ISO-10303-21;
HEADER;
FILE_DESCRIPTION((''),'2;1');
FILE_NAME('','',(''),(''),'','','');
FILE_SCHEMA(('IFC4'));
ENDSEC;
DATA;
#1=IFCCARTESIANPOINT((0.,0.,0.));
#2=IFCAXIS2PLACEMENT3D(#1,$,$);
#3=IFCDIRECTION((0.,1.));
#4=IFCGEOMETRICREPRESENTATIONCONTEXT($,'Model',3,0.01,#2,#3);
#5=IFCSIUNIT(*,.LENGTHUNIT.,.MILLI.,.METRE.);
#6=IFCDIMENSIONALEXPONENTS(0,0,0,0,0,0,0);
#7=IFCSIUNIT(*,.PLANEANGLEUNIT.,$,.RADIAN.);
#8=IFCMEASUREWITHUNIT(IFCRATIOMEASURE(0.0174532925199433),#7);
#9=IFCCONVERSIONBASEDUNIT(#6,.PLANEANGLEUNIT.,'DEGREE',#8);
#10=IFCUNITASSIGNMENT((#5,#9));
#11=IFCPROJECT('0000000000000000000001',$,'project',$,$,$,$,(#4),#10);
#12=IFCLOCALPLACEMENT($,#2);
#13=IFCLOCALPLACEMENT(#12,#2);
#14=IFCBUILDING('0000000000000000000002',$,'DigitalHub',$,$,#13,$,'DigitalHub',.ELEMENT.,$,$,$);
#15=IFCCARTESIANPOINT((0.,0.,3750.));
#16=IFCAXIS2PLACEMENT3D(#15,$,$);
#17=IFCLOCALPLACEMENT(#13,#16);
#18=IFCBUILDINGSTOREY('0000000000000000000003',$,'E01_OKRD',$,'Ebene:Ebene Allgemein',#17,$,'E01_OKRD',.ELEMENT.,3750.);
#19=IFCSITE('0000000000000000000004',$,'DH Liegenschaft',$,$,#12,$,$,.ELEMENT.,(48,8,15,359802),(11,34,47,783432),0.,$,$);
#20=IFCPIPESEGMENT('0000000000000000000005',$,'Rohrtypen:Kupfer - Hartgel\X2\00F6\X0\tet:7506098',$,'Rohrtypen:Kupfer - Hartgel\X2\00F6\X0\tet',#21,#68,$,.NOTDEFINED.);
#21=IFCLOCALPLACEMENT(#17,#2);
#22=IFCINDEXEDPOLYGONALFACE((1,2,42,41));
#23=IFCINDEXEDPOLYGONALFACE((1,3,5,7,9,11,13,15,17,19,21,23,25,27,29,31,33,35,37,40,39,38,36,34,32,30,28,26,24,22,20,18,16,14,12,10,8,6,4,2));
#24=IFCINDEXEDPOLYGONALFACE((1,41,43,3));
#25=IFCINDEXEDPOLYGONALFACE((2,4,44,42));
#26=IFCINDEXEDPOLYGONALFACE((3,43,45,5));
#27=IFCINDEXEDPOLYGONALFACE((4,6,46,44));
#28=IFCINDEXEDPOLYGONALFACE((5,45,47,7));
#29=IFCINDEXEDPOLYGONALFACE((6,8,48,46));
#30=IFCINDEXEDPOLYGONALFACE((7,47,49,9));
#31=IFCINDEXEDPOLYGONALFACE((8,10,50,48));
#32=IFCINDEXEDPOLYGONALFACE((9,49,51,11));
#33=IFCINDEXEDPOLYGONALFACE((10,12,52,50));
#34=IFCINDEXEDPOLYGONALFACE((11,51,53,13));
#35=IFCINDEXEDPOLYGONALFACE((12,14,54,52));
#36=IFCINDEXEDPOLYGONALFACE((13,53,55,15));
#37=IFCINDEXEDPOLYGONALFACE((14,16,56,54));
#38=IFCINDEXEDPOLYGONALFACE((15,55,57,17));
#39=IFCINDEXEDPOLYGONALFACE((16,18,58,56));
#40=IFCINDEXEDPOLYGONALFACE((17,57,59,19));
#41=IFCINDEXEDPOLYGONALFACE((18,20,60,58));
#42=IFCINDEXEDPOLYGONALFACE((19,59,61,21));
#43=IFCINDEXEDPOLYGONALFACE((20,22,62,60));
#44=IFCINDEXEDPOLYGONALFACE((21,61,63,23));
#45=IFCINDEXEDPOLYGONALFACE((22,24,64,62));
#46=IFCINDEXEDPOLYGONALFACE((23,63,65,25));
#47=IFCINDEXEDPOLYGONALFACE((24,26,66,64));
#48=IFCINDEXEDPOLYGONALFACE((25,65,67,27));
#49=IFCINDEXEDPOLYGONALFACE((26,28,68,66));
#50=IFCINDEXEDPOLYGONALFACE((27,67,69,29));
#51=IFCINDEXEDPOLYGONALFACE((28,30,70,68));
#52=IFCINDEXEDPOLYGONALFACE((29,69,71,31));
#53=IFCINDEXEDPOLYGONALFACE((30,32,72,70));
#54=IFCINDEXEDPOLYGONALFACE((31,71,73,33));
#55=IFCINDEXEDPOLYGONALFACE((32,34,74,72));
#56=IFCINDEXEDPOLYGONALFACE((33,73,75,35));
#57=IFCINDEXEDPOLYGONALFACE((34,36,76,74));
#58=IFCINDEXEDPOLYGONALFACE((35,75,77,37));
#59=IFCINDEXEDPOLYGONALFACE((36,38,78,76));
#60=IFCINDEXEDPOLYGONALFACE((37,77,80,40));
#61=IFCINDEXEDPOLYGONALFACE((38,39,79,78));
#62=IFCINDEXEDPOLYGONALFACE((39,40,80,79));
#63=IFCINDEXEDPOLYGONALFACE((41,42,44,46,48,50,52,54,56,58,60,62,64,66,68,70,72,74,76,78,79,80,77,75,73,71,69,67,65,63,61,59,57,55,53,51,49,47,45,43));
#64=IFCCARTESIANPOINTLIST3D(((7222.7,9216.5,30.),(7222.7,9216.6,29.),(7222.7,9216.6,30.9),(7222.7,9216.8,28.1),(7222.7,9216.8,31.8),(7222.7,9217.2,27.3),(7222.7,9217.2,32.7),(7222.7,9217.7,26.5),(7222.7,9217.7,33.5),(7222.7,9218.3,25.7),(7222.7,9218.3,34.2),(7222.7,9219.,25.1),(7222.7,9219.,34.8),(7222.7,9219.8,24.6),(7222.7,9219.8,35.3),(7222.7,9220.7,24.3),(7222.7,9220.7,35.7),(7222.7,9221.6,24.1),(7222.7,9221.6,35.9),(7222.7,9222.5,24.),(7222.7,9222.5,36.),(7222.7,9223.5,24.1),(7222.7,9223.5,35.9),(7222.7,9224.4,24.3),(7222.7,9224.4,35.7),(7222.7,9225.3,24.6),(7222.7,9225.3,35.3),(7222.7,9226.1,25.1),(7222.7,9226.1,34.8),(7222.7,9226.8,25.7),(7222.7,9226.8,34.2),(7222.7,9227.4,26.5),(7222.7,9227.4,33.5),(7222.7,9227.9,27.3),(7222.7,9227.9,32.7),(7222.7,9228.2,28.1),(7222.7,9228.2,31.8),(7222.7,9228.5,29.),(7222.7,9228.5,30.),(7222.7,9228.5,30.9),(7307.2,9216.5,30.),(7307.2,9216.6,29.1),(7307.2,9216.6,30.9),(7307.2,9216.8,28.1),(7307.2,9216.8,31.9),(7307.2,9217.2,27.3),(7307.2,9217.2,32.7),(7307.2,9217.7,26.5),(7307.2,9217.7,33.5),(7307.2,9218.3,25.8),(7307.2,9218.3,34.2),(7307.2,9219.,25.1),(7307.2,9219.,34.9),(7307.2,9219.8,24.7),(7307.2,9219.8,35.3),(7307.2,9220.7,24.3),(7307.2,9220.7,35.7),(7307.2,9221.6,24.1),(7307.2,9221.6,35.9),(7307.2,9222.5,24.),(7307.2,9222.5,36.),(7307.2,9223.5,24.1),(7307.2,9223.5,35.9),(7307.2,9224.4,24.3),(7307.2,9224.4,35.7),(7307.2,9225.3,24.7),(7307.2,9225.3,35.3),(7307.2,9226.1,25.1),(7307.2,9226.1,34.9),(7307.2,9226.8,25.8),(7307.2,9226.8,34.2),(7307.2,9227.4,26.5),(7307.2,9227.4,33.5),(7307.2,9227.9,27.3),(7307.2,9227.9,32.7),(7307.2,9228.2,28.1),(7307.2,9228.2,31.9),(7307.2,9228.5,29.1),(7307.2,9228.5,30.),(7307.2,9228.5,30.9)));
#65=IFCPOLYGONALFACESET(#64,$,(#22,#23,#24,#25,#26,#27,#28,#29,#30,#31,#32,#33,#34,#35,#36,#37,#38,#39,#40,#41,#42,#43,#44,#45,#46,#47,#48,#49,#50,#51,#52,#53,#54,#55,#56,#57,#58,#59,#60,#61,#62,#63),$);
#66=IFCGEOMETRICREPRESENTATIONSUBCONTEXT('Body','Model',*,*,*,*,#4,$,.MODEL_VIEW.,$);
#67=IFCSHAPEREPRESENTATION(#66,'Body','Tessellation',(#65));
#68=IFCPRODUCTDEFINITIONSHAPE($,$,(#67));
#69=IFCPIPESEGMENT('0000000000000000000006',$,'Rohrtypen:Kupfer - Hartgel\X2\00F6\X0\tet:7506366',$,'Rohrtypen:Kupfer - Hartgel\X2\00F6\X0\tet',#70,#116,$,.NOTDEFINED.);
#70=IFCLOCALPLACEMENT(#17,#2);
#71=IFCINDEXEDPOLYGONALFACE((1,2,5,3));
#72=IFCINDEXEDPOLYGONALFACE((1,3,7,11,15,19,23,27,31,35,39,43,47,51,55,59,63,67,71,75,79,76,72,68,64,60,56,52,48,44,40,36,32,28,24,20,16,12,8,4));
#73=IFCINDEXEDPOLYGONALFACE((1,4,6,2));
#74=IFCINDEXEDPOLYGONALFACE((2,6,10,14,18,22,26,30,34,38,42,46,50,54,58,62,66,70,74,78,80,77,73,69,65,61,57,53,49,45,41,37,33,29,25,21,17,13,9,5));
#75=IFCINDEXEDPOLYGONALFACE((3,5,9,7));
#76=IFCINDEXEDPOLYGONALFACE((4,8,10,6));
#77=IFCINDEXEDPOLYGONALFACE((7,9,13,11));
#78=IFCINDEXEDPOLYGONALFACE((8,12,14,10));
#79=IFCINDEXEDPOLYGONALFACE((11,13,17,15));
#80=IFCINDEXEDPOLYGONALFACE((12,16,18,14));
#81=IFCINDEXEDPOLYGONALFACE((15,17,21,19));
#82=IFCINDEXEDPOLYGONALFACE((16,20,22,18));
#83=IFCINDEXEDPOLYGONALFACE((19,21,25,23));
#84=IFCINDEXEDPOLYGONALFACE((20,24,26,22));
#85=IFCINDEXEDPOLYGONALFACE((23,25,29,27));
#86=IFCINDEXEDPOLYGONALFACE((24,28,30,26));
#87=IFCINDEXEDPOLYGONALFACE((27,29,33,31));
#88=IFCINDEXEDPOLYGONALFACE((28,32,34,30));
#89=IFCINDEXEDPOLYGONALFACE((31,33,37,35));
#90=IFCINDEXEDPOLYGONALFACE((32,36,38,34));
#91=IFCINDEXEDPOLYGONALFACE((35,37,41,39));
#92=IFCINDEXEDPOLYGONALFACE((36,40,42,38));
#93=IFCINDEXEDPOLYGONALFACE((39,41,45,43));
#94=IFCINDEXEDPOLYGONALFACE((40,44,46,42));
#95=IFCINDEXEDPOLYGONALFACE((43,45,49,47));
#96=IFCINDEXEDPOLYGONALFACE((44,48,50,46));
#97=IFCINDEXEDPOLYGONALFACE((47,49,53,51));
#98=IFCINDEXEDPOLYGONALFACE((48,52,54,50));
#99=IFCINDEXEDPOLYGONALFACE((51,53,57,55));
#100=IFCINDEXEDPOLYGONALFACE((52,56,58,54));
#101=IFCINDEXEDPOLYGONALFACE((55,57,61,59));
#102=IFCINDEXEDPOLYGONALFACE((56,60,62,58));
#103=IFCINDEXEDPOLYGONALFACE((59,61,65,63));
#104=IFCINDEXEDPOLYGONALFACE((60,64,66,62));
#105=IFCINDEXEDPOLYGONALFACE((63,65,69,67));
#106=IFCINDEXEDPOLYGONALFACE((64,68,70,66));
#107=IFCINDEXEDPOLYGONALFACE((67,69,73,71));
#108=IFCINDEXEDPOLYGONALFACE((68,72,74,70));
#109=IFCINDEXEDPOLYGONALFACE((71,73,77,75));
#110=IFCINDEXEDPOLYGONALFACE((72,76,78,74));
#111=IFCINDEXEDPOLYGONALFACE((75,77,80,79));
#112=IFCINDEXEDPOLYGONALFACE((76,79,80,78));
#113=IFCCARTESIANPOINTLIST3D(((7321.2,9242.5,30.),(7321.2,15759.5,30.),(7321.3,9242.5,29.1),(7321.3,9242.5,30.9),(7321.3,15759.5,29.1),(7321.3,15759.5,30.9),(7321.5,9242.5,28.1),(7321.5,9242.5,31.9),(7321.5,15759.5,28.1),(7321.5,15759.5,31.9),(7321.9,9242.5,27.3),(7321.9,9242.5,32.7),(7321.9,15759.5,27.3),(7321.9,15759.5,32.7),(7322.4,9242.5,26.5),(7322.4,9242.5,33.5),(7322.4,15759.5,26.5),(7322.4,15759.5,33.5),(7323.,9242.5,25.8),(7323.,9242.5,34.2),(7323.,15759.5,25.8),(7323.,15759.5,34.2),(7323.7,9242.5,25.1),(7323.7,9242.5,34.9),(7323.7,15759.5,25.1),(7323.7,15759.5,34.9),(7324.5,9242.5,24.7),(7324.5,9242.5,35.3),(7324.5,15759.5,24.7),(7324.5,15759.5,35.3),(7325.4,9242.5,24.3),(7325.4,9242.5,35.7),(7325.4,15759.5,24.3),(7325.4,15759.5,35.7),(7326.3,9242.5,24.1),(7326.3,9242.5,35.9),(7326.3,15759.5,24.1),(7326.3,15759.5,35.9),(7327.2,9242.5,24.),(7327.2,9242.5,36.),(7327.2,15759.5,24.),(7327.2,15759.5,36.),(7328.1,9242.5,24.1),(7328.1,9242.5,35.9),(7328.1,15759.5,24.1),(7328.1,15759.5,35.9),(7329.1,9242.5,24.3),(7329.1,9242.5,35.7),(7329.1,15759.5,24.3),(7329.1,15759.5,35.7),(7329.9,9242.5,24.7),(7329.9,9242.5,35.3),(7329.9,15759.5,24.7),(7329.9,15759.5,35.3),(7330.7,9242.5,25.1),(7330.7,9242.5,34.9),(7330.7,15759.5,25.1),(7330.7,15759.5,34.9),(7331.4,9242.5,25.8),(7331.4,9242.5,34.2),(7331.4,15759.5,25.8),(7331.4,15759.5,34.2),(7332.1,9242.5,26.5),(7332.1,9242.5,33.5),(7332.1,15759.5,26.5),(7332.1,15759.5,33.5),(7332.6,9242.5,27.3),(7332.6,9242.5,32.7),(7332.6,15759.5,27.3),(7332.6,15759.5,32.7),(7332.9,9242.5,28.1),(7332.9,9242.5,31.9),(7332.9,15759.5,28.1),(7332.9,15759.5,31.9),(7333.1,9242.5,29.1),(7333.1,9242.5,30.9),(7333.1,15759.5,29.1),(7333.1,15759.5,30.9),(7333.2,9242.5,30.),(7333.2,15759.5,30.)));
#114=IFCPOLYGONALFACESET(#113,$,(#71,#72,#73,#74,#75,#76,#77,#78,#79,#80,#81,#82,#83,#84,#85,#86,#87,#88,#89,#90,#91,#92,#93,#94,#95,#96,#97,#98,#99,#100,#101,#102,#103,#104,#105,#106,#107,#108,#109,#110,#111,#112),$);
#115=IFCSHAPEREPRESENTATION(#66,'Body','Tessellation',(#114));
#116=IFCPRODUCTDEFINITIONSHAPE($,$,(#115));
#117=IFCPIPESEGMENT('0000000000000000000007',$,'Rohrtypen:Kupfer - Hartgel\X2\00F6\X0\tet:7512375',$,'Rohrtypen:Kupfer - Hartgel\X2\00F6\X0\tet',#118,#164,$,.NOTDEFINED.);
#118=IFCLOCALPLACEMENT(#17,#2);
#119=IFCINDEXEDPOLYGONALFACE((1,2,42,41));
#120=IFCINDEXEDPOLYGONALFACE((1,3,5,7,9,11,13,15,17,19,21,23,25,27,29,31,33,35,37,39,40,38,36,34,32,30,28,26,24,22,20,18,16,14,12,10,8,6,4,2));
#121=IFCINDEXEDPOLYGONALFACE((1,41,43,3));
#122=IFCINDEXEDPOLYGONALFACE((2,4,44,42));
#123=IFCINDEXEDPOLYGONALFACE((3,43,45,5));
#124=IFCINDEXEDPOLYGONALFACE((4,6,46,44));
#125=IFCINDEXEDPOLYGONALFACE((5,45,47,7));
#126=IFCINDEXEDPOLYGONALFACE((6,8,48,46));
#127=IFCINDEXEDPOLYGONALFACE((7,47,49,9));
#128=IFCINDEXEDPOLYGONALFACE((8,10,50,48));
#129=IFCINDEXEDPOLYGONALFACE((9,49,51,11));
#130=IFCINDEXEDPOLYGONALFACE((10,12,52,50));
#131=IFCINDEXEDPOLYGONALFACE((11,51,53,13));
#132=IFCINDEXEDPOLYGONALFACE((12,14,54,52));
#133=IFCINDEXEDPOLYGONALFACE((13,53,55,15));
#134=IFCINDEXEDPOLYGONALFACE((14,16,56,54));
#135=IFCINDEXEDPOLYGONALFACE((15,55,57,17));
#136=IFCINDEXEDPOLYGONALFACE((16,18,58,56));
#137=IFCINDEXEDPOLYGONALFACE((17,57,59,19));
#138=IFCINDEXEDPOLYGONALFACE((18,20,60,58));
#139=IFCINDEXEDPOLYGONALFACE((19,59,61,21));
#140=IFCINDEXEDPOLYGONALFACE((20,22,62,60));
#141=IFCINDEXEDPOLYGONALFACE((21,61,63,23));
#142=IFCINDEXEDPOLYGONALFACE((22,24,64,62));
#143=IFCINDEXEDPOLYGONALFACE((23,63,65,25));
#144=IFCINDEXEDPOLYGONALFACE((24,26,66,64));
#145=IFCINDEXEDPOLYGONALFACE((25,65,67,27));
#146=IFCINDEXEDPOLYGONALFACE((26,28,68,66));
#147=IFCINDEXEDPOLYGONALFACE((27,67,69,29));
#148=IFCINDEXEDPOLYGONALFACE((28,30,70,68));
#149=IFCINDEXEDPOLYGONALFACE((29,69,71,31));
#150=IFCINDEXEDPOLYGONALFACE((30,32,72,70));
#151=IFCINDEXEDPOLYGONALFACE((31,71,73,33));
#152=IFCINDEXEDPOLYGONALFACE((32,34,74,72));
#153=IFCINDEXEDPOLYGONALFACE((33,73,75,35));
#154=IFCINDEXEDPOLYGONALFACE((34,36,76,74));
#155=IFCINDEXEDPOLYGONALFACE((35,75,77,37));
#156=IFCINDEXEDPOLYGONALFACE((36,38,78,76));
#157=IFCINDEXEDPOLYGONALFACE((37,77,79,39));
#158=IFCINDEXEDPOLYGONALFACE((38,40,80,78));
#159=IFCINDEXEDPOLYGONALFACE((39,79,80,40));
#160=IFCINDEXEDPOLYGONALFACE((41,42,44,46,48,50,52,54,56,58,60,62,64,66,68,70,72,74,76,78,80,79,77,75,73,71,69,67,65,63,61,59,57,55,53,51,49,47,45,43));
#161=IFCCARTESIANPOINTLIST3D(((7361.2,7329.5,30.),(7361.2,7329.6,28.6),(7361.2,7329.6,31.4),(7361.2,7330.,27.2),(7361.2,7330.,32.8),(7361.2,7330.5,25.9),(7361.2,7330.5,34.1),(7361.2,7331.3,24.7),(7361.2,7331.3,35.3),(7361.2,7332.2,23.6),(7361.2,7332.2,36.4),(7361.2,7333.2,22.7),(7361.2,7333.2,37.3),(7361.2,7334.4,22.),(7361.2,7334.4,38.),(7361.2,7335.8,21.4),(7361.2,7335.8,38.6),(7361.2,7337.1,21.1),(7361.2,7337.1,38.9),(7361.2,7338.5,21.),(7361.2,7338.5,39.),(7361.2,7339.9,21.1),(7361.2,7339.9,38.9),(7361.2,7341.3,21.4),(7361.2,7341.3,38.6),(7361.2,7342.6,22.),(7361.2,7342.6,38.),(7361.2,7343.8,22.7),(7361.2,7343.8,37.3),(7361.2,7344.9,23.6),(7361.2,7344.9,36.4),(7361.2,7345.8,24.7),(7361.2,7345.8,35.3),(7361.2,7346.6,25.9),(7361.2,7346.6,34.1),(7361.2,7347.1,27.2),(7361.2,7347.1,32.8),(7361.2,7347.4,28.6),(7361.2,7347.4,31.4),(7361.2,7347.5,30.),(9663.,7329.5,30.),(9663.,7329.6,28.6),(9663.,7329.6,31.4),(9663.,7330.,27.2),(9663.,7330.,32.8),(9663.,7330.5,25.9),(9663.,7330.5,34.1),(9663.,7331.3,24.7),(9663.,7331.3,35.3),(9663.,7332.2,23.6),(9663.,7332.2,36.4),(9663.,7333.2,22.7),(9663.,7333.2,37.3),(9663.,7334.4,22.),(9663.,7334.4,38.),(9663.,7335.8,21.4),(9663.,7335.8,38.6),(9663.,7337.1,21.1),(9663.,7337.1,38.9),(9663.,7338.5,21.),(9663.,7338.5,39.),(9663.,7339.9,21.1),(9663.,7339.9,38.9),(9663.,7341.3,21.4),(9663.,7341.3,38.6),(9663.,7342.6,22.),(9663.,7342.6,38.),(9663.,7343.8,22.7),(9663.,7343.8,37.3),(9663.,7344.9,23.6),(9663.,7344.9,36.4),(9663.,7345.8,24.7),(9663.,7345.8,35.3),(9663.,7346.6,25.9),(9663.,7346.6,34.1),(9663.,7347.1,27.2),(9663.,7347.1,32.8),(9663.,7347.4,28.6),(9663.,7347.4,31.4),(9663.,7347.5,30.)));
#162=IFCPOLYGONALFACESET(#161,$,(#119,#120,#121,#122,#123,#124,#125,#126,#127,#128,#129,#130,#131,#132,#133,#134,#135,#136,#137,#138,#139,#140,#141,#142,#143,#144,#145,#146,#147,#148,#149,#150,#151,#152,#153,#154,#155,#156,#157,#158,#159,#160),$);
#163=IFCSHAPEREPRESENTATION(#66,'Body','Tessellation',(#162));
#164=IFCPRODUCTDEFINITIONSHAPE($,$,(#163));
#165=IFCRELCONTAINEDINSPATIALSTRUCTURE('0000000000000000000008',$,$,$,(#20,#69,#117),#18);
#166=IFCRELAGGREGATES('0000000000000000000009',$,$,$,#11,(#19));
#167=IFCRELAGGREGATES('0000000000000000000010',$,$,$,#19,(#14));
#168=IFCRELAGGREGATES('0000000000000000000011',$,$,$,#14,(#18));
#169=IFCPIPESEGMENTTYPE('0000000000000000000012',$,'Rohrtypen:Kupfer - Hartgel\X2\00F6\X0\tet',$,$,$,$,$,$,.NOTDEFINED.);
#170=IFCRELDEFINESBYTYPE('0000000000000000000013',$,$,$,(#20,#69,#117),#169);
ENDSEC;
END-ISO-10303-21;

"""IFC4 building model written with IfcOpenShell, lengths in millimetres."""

from ifc_helpers import new_model, entity, si_unit, converted_unit, direction, frame, origin, place, context, subcontext, project, spatial, indexed_curve, outline, extrude, type_object, element, save


model = new_model("IFC4")

# Units and contexts
model_context = context("Model", 3, precision=0.01, world=origin(), true_north=direction((0.0, 1.0)))
body_context = subcontext(model_context, "Body", "Model", "MODEL_VIEW")
ifc_project = project(units=[si_unit("LENGTHUNIT", "METRE", prefix="MILLI"), converted_unit("PLANEANGLEUNIT", "DEGREE", entity("IfcRatioMeasure", 0.0174532925199433), si_unit("PLANEANGLEUNIT", "RADIAN"), dimensions=[0, 0, 0, 0, 0, 0, 0])], contexts=[model_context])

# Site, building, storey
site_placement = place(None, origin())
site = spatial("IfcSite", under=ifc_project, at=site_placement, Name="DH Liegenschaft", CompositionType="ELEMENT", RefLatitude=(48, 8, 15, 359802), RefLongitude=(11, 34, 47, 783432), RefElevation=0.0)
building_placement = place(site_placement, origin())
building = spatial("IfcBuilding", under=site, at=building_placement, Name="DigitalHub", LongName="DigitalHub", CompositionType="ELEMENT")
storey_placement = place(building_placement, frame((0.0, 0.0, 3750.0)))
storey = spatial("IfcBuildingStorey", under=building, at=storey_placement, Name="E01_OKRD", ObjectType="Ebene:Ebene Allgemein", LongName="E01_OKRD", CompositionType="ELEMENT", Elevation=3750.0)

# Pipe segments
pipe_segment_type = type_object("IfcPipeSegmentType", Name="Rohrtypen:Kupfer - Hartgelötet", PredefinedType="NOTDEFINED")
pipe_segment_1_placement = place(storey_placement, frame((7222.7, 9214.9, 22.4)))
element("IfcPipeSegment", 1, at=pipe_segment_1_placement, inside=storey, type_object=pipe_segment_type, Name="Rohrtypen:Kupfer - Hartgelötet:7506098", ObjectType="Rohrtypen:Kupfer - Hartgelötet", PredefinedType="NOTDEFINED", context=body_context, shape_type="SweptSolid", body=[
    extrude(outline(indexed_curve([(6.0, 0.0), (5.9, 0.9), (5.7, 1.9), (5.3, 2.7), (4.9, 3.5), (4.2, 4.2), (3.5, 4.9), (2.7, 5.3), (1.9, 5.7), (0.9, 5.9), (0.0, 6.0), (-0.9, 5.9), (-1.9, 5.7), (-2.7, 5.3), (-3.5, 4.9), (-4.2, 4.2), (-4.9, 3.5), (-5.3, 2.7), (-5.7, 1.9), (-5.9, 0.9), (-6.0, 0.0), (-5.9, -0.9), (-5.7, -1.9), (-5.3, -2.7), (-4.9, -3.5), (-4.2, -4.2), (-3.5, -4.9), (-2.7, -5.3), (-1.9, -5.7), (-0.9, -5.9), (0.0, -6.0), (0.9, -5.9), (1.9, -5.7), (2.7, -5.3), (3.5, -4.9), (4.2, -4.2), (4.9, -3.5), (5.3, -2.7), (5.7, -1.9), (5.9, -0.9), (6.0, 0.0)], self_intersect=False)), frame((0.0, 7.6, 7.6), z_axis=(1.0, 0.0, 0.00013), x_axis=(0.0, -1.0, 0.0)), (0.0, 0.0, 1.0), 84.5),
])
pipe_segment_2_placement = place(storey_placement, frame((7319.6, 9242.5, 22.4)))
element("IfcPipeSegment", 2, at=pipe_segment_2_placement, inside=storey, type_object=pipe_segment_type, Name="Rohrtypen:Kupfer - Hartgelötet:7506366", ObjectType="Rohrtypen:Kupfer - Hartgelötet", PredefinedType="NOTDEFINED", context=body_context, shape_type="SweptSolid", body=[
    extrude(outline(indexed_curve([(6.0, 0.0), (5.9, 0.9), (5.7, 1.9), (5.3, 2.7), (4.9, 3.5), (4.2, 4.2), (3.5, 4.9), (2.7, 5.3), (1.9, 5.7), (0.9, 5.9), (0.0, 6.0), (-0.9, 5.9), (-1.9, 5.7), (-2.7, 5.3), (-3.5, 4.9), (-4.2, 4.2), (-4.9, 3.5), (-5.3, 2.7), (-5.7, 1.9), (-5.9, 0.9), (-6.0, 0.0), (-5.9, -0.9), (-5.7, -1.9), (-5.3, -2.7), (-4.9, -3.5), (-4.2, -4.2), (-3.5, -4.9), (-2.7, -5.3), (-1.9, -5.7), (-0.9, -5.9), (0.0, -6.0), (0.9, -5.9), (1.9, -5.7), (2.7, -5.3), (3.5, -4.9), (4.2, -4.2), (4.9, -3.5), (5.3, -2.7), (5.7, -1.9), (5.9, -0.9), (6.0, 0.0)], self_intersect=False)), frame((7.6, 0.0, 7.6), z_axis=(0.0, 1.0, 0.0), x_axis=(-1.0, 0.0, 0.0)), (0.0, 0.0, 1.0), 6517.0),
])
pipe_segment_3_placement = place(storey_placement, frame((7361.2, 7327.9, 19.4)))
element("IfcPipeSegment", 3, at=pipe_segment_3_placement, inside=storey, type_object=pipe_segment_type, Name="Rohrtypen:Kupfer - Hartgelötet:7512375", ObjectType="Rohrtypen:Kupfer - Hartgelötet", PredefinedType="NOTDEFINED", context=body_context, shape_type="SweptSolid", body=[
    extrude(outline(indexed_curve([(9.0, 0.0), (8.9, 1.4), (8.6, 2.8), (8.0, 4.1), (7.3, 5.3), (6.4, 6.4), (5.3, 7.3), (4.1, 8.0), (2.8, 8.6), (1.4, 8.9), (0.0, 9.0), (-1.4, 8.9), (-2.8, 8.6), (-4.1, 8.0), (-5.3, 7.3), (-6.4, 6.4), (-7.3, 5.3), (-8.0, 4.1), (-8.6, 2.8), (-8.9, 1.4), (-9.0, 0.0), (-8.9, -1.4), (-8.6, -2.8), (-8.0, -4.1), (-7.3, -5.3), (-6.4, -6.4), (-5.3, -7.3), (-4.1, -8.0), (-2.8, -8.6), (-1.4, -8.9), (0.0, -9.0), (1.4, -8.9), (2.8, -8.6), (4.1, -8.0), (5.3, -7.3), (6.4, -6.4), (7.3, -5.3), (8.0, -4.1), (8.6, -2.8), (8.9, -1.4), (9.0, 0.0)], self_intersect=False)), frame((0.0, 10.6, 10.6), z_axis=(1.0, 0.0, 0.0), x_axis=(0.0, 1.0, 0.0)), (0.0, 0.0, 1.0), 2301.7),
])

save(model, "model.ifc")
